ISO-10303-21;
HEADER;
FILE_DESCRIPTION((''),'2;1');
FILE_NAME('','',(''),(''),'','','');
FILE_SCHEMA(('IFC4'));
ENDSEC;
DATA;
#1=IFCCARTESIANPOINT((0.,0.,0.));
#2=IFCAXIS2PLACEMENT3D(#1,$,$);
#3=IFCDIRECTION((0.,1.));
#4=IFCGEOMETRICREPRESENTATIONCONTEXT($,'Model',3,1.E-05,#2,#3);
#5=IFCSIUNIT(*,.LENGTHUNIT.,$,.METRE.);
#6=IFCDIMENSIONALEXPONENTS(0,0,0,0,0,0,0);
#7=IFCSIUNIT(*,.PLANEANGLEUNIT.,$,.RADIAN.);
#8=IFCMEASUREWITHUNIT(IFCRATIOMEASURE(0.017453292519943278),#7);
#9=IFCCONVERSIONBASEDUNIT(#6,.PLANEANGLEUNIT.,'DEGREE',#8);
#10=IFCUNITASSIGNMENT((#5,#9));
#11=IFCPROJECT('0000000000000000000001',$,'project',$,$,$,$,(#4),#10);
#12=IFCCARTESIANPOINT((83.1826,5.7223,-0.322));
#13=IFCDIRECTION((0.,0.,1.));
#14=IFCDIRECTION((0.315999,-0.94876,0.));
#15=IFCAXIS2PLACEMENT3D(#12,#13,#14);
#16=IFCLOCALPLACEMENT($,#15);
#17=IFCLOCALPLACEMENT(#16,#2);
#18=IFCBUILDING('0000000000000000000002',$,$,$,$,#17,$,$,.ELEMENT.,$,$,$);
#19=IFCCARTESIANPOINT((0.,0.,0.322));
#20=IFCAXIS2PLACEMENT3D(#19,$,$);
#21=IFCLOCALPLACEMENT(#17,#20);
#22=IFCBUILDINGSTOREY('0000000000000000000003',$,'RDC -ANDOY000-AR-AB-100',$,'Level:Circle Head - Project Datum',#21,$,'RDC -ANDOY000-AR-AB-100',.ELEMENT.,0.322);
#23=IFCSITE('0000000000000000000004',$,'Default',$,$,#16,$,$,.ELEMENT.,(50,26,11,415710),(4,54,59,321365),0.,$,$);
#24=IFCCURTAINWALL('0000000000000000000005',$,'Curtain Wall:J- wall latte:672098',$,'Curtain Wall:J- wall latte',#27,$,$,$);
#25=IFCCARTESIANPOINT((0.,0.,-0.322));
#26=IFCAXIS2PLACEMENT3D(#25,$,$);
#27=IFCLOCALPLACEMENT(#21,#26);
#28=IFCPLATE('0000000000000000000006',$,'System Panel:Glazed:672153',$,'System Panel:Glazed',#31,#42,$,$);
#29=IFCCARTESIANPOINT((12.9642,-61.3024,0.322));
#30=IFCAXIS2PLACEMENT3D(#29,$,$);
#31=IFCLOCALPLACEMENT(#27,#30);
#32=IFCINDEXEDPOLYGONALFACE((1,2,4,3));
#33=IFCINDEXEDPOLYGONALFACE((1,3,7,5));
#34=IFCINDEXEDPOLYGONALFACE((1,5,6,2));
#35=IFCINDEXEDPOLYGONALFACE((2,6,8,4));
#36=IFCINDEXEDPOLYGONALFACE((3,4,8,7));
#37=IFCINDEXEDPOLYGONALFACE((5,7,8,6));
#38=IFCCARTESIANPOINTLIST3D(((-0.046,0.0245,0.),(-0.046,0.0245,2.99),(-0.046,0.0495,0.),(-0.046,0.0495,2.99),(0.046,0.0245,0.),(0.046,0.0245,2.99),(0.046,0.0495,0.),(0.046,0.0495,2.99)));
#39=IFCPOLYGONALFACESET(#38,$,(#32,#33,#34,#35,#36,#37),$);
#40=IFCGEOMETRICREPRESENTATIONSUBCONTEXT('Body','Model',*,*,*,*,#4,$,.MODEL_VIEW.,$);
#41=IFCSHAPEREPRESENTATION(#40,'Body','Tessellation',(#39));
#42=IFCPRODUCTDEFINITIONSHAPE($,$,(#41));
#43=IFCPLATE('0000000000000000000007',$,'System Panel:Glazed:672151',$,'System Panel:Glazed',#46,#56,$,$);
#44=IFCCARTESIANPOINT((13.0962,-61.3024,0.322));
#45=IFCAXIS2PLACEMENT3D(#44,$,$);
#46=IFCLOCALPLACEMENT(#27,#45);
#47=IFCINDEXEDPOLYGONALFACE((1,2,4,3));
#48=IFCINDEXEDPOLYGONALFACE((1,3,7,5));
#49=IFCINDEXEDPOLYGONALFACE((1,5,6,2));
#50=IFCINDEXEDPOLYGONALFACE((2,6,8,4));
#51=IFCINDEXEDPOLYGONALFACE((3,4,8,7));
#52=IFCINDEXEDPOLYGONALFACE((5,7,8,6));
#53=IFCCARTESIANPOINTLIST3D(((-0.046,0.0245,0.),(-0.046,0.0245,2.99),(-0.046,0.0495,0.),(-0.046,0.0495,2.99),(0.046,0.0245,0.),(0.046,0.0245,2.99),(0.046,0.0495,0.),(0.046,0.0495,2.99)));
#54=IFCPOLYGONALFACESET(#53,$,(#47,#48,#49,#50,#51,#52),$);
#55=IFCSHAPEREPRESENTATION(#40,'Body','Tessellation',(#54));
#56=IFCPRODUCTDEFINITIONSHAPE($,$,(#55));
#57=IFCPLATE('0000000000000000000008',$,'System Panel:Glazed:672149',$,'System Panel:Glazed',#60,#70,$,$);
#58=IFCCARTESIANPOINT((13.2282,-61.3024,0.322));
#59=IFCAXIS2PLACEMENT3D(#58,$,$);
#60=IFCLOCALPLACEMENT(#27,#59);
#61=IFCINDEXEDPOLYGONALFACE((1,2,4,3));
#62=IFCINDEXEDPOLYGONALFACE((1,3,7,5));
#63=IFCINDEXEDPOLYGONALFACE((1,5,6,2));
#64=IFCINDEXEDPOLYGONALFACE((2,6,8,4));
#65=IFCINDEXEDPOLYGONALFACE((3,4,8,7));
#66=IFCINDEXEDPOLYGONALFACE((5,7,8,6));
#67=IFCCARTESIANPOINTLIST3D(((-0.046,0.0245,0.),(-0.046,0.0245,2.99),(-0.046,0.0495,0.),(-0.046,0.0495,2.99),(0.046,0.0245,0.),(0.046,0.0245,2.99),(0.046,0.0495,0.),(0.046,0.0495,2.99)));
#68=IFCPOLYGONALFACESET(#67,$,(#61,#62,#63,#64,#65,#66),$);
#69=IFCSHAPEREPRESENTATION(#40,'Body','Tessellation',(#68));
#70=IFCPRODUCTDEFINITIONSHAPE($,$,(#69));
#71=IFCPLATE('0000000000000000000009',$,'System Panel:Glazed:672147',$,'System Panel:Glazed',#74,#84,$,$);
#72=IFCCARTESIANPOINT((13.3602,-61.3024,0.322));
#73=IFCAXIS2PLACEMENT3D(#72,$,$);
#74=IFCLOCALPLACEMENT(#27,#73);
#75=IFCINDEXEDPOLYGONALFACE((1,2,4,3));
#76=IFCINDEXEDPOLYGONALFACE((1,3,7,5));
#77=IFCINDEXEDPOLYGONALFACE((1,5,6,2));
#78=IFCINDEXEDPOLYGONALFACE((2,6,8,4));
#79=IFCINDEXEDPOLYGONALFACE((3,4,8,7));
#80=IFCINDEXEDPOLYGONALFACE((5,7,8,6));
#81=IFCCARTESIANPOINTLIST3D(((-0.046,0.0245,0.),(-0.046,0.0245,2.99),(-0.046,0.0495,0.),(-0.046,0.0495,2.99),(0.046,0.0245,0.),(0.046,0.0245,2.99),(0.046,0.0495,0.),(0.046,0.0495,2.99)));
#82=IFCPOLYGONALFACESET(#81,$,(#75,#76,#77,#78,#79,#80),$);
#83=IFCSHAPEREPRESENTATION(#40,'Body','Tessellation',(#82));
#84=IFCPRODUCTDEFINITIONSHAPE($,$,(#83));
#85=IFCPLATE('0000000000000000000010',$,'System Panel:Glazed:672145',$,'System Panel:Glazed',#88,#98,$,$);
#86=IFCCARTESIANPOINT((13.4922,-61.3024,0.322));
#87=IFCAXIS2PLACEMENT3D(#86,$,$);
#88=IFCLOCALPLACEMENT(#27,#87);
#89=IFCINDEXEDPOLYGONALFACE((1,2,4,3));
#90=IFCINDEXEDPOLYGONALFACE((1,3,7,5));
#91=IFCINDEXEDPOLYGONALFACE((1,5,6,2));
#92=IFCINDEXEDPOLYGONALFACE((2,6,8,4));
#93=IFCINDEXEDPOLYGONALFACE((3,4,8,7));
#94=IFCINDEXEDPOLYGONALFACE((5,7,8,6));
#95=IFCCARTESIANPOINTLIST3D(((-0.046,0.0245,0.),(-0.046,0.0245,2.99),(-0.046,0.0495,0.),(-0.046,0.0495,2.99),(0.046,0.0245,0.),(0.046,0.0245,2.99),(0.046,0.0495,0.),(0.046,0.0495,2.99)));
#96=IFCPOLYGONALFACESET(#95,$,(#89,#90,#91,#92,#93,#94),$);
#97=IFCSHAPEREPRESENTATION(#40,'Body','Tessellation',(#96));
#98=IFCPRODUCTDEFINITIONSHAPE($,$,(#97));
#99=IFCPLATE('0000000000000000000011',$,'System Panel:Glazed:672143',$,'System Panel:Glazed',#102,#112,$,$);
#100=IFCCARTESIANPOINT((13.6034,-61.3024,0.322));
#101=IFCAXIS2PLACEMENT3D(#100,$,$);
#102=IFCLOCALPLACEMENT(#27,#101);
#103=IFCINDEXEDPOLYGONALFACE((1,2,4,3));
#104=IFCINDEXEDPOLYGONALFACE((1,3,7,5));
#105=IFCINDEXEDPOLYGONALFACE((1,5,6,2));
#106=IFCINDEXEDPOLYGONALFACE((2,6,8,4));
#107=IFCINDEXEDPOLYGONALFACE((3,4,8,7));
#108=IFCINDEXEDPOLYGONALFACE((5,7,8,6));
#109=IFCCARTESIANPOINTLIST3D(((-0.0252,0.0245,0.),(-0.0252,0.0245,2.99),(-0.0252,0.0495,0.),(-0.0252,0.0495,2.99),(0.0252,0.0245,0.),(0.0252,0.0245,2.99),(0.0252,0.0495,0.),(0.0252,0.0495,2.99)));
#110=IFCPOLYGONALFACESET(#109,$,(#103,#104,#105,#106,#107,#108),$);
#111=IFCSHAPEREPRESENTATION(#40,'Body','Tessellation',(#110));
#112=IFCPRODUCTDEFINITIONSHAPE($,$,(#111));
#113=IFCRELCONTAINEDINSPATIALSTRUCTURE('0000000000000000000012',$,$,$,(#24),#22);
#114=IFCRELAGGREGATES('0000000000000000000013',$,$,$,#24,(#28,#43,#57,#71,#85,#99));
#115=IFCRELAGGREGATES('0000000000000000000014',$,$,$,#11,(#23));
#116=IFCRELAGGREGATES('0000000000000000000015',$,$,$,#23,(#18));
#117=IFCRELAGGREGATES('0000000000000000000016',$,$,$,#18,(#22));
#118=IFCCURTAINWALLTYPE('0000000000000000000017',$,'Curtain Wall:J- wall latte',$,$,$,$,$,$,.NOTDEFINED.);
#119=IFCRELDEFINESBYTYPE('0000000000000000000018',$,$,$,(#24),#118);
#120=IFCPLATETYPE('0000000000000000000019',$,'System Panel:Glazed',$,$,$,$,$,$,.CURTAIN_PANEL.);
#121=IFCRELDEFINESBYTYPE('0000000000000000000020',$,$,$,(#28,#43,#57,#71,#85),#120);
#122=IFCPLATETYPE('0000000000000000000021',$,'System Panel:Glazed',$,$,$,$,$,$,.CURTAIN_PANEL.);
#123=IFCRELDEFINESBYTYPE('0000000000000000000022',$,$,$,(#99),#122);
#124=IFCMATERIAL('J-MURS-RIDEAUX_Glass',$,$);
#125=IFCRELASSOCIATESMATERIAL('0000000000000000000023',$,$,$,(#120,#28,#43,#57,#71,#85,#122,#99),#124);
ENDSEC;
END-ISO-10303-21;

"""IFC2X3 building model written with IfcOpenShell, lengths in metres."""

from ifc_helpers import new_model, entity, si_unit, converted_unit, direction, frame, frame_2d, origin, origin_2d_with_axis, place, context, subcontext, project, spatial, rectangle, extrude, source, transform, mapped, material, type_object, type_shapes, element, aggregate, save


model = new_model("IFC2X3")

# Units and contexts
model_context = context("Model", 3, precision=1e-05, world=origin(), true_north=direction((0.0, 1.0)))
body_context = subcontext(model_context, "Body", "Model", "MODEL_VIEW")
ifc_project = project(units=[si_unit("LENGTHUNIT", "METRE"), converted_unit("PLANEANGLEUNIT", "DEGREE", entity("IfcRatioMeasure", 0.017453292519943278), si_unit("PLANEANGLEUNIT", "RADIAN"), dimensions=[0, 0, 0, 0, 0, 0, 0])], contexts=[model_context])

# Site, building, storey
site_placement = place(None, frame((83.1826, 5.7223, -0.322), z_axis=(0.0, 0.0, 1.0), x_axis=(0.315999, -0.94876, 0.0)))
site = spatial("IfcSite", under=ifc_project, at=site_placement, Name="Default", CompositionType="ELEMENT", RefLatitude=(50, 26, 11, 415710), RefLongitude=(4, 54, 59, 321365), RefElevation=0.0)
building_placement = place(site_placement, origin())
building = spatial("IfcBuilding", under=site, at=building_placement, CompositionType="ELEMENT")
storey_placement = place(building_placement, frame((0.0, 0.0, 0.322)))
storey = spatial("IfcBuildingStorey", under=building, at=storey_placement, Name="RDC -ANDOY000-AR-AB-100", ObjectType="Level:Circle Head - Project Datum", LongName="RDC -ANDOY000-AR-AB-100", CompositionType="ELEMENT", Elevation=0.322)

# Curtain wall
curtain_wall_type = type_object("IfcCurtainWallType", Name="Curtain Wall:J- wall latte", PredefinedType="NOTDEFINED")
curtain_wall_1_placement = place(storey_placement, frame((0.0, 0.0, -0.322)))
curtain_wall_1 = element("IfcCurtainWall", 1, at=curtain_wall_1_placement, inside=storey, type_object=curtain_wall_type, Name="Curtain Wall:J- wall latte:672098", ObjectType="Curtain Wall:J- wall latte")

# Plates
ifc_material_1 = material(Name="J-MURS-RIDEAUX_Glass")
plate_type_1 = type_object("IfcPlateType", Name="System Panel:Glazed", PredefinedType="CURTAIN_PANEL", material=ifc_material_1)
shared_shape_1 = source(origin(), body_context, "Body", "SweptSolid", [
    extrude(rectangle(XDim=0.025, YDim=0.092, at=frame_2d((0.0, 0.0), x_axis=(1.0, 0.0))), frame((0.0, 0.037, 0.0), z_axis=(0.0, 0.0, 1.0), x_axis=(0.0, 1.0, 0.0)), (0.0, 0.0, 1.0), 2.99),
])
type_shapes(plate_type_1, [shared_shape_1])
plate_1_placement = place(curtain_wall_1_placement, frame((12.9642, -61.3024, 0.322)))
plate_1 = element("IfcPlate", 2, at=plate_1_placement, type_object=plate_type_1, material=ifc_material_1, Name="System Panel:Glazed:672153", ObjectType="System Panel:Glazed", context=body_context, shape_type="MappedRepresentation", body=[
    mapped(shared_shape_1, transform((0.0, 0.0, 0.0), scale=1.0)),
])
plate_2_placement = place(curtain_wall_1_placement, frame((13.0962, -61.3024, 0.322)))
plate_2 = element("IfcPlate", 3, at=plate_2_placement, type_object=plate_type_1, material=ifc_material_1, Name="System Panel:Glazed:672151", ObjectType="System Panel:Glazed", context=body_context, shape_type="MappedRepresentation", body=[
    mapped(shared_shape_1, transform((0.0, 0.0, 0.0), scale=1.0)),
])
plate_3_placement = place(curtain_wall_1_placement, frame((13.2282, -61.3024, 0.322)))
plate_3 = element("IfcPlate", 4, at=plate_3_placement, type_object=plate_type_1, material=ifc_material_1, Name="System Panel:Glazed:672149", ObjectType="System Panel:Glazed", context=body_context, shape_type="MappedRepresentation", body=[
    mapped(shared_shape_1, transform((0.0, 0.0, 0.0), scale=1.0)),
])
plate_4_placement = place(curtain_wall_1_placement, frame((13.3602, -61.3024, 0.322)))
plate_4 = element("IfcPlate", 5, at=plate_4_placement, type_object=plate_type_1, material=ifc_material_1, Name="System Panel:Glazed:672147", ObjectType="System Panel:Glazed", context=body_context, shape_type="MappedRepresentation", body=[
    mapped(shared_shape_1, transform((0.0, 0.0, 0.0), scale=1.0)),
])
plate_5_placement = place(curtain_wall_1_placement, frame((13.4922, -61.3024, 0.322)))
plate_5 = element("IfcPlate", 6, at=plate_5_placement, type_object=plate_type_1, material=ifc_material_1, Name="System Panel:Glazed:672145", ObjectType="System Panel:Glazed", context=body_context, shape_type="MappedRepresentation", body=[
    mapped(shared_shape_1, transform((0.0, 0.0, 0.0), scale=1.0)),
])
plate_type_2 = type_object("IfcPlateType", Name="System Panel:Glazed", PredefinedType="CURTAIN_PANEL", material=ifc_material_1)
shared_shape_2 = source(origin(), body_context, "Body", "SweptSolid", [
    extrude(rectangle(XDim=0.025, YDim=0.0504, at=origin_2d_with_axis()), frame((0.0, 0.037, 0.0), z_axis=(0.0, 0.0, 1.0), x_axis=(0.0, 1.0, 0.0)), (0.0, 0.0, 1.0), 2.99),
])
type_shapes(plate_type_2, [shared_shape_2])
plate_6_placement = place(curtain_wall_1_placement, frame((13.6034, -61.3024, 0.322)))
plate_6 = element("IfcPlate", 7, at=plate_6_placement, type_object=plate_type_2, material=ifc_material_1, Name="System Panel:Glazed:672143", ObjectType="System Panel:Glazed", context=body_context, shape_type="MappedRepresentation", body=[
    mapped(shared_shape_2, transform((0.0, 0.0, 0.0), scale=1.0)),
])
aggregate(curtain_wall_1, [plate_1, plate_2, plate_3, plate_4, plate_5, plate_6])

save(model, "model.ifc")
